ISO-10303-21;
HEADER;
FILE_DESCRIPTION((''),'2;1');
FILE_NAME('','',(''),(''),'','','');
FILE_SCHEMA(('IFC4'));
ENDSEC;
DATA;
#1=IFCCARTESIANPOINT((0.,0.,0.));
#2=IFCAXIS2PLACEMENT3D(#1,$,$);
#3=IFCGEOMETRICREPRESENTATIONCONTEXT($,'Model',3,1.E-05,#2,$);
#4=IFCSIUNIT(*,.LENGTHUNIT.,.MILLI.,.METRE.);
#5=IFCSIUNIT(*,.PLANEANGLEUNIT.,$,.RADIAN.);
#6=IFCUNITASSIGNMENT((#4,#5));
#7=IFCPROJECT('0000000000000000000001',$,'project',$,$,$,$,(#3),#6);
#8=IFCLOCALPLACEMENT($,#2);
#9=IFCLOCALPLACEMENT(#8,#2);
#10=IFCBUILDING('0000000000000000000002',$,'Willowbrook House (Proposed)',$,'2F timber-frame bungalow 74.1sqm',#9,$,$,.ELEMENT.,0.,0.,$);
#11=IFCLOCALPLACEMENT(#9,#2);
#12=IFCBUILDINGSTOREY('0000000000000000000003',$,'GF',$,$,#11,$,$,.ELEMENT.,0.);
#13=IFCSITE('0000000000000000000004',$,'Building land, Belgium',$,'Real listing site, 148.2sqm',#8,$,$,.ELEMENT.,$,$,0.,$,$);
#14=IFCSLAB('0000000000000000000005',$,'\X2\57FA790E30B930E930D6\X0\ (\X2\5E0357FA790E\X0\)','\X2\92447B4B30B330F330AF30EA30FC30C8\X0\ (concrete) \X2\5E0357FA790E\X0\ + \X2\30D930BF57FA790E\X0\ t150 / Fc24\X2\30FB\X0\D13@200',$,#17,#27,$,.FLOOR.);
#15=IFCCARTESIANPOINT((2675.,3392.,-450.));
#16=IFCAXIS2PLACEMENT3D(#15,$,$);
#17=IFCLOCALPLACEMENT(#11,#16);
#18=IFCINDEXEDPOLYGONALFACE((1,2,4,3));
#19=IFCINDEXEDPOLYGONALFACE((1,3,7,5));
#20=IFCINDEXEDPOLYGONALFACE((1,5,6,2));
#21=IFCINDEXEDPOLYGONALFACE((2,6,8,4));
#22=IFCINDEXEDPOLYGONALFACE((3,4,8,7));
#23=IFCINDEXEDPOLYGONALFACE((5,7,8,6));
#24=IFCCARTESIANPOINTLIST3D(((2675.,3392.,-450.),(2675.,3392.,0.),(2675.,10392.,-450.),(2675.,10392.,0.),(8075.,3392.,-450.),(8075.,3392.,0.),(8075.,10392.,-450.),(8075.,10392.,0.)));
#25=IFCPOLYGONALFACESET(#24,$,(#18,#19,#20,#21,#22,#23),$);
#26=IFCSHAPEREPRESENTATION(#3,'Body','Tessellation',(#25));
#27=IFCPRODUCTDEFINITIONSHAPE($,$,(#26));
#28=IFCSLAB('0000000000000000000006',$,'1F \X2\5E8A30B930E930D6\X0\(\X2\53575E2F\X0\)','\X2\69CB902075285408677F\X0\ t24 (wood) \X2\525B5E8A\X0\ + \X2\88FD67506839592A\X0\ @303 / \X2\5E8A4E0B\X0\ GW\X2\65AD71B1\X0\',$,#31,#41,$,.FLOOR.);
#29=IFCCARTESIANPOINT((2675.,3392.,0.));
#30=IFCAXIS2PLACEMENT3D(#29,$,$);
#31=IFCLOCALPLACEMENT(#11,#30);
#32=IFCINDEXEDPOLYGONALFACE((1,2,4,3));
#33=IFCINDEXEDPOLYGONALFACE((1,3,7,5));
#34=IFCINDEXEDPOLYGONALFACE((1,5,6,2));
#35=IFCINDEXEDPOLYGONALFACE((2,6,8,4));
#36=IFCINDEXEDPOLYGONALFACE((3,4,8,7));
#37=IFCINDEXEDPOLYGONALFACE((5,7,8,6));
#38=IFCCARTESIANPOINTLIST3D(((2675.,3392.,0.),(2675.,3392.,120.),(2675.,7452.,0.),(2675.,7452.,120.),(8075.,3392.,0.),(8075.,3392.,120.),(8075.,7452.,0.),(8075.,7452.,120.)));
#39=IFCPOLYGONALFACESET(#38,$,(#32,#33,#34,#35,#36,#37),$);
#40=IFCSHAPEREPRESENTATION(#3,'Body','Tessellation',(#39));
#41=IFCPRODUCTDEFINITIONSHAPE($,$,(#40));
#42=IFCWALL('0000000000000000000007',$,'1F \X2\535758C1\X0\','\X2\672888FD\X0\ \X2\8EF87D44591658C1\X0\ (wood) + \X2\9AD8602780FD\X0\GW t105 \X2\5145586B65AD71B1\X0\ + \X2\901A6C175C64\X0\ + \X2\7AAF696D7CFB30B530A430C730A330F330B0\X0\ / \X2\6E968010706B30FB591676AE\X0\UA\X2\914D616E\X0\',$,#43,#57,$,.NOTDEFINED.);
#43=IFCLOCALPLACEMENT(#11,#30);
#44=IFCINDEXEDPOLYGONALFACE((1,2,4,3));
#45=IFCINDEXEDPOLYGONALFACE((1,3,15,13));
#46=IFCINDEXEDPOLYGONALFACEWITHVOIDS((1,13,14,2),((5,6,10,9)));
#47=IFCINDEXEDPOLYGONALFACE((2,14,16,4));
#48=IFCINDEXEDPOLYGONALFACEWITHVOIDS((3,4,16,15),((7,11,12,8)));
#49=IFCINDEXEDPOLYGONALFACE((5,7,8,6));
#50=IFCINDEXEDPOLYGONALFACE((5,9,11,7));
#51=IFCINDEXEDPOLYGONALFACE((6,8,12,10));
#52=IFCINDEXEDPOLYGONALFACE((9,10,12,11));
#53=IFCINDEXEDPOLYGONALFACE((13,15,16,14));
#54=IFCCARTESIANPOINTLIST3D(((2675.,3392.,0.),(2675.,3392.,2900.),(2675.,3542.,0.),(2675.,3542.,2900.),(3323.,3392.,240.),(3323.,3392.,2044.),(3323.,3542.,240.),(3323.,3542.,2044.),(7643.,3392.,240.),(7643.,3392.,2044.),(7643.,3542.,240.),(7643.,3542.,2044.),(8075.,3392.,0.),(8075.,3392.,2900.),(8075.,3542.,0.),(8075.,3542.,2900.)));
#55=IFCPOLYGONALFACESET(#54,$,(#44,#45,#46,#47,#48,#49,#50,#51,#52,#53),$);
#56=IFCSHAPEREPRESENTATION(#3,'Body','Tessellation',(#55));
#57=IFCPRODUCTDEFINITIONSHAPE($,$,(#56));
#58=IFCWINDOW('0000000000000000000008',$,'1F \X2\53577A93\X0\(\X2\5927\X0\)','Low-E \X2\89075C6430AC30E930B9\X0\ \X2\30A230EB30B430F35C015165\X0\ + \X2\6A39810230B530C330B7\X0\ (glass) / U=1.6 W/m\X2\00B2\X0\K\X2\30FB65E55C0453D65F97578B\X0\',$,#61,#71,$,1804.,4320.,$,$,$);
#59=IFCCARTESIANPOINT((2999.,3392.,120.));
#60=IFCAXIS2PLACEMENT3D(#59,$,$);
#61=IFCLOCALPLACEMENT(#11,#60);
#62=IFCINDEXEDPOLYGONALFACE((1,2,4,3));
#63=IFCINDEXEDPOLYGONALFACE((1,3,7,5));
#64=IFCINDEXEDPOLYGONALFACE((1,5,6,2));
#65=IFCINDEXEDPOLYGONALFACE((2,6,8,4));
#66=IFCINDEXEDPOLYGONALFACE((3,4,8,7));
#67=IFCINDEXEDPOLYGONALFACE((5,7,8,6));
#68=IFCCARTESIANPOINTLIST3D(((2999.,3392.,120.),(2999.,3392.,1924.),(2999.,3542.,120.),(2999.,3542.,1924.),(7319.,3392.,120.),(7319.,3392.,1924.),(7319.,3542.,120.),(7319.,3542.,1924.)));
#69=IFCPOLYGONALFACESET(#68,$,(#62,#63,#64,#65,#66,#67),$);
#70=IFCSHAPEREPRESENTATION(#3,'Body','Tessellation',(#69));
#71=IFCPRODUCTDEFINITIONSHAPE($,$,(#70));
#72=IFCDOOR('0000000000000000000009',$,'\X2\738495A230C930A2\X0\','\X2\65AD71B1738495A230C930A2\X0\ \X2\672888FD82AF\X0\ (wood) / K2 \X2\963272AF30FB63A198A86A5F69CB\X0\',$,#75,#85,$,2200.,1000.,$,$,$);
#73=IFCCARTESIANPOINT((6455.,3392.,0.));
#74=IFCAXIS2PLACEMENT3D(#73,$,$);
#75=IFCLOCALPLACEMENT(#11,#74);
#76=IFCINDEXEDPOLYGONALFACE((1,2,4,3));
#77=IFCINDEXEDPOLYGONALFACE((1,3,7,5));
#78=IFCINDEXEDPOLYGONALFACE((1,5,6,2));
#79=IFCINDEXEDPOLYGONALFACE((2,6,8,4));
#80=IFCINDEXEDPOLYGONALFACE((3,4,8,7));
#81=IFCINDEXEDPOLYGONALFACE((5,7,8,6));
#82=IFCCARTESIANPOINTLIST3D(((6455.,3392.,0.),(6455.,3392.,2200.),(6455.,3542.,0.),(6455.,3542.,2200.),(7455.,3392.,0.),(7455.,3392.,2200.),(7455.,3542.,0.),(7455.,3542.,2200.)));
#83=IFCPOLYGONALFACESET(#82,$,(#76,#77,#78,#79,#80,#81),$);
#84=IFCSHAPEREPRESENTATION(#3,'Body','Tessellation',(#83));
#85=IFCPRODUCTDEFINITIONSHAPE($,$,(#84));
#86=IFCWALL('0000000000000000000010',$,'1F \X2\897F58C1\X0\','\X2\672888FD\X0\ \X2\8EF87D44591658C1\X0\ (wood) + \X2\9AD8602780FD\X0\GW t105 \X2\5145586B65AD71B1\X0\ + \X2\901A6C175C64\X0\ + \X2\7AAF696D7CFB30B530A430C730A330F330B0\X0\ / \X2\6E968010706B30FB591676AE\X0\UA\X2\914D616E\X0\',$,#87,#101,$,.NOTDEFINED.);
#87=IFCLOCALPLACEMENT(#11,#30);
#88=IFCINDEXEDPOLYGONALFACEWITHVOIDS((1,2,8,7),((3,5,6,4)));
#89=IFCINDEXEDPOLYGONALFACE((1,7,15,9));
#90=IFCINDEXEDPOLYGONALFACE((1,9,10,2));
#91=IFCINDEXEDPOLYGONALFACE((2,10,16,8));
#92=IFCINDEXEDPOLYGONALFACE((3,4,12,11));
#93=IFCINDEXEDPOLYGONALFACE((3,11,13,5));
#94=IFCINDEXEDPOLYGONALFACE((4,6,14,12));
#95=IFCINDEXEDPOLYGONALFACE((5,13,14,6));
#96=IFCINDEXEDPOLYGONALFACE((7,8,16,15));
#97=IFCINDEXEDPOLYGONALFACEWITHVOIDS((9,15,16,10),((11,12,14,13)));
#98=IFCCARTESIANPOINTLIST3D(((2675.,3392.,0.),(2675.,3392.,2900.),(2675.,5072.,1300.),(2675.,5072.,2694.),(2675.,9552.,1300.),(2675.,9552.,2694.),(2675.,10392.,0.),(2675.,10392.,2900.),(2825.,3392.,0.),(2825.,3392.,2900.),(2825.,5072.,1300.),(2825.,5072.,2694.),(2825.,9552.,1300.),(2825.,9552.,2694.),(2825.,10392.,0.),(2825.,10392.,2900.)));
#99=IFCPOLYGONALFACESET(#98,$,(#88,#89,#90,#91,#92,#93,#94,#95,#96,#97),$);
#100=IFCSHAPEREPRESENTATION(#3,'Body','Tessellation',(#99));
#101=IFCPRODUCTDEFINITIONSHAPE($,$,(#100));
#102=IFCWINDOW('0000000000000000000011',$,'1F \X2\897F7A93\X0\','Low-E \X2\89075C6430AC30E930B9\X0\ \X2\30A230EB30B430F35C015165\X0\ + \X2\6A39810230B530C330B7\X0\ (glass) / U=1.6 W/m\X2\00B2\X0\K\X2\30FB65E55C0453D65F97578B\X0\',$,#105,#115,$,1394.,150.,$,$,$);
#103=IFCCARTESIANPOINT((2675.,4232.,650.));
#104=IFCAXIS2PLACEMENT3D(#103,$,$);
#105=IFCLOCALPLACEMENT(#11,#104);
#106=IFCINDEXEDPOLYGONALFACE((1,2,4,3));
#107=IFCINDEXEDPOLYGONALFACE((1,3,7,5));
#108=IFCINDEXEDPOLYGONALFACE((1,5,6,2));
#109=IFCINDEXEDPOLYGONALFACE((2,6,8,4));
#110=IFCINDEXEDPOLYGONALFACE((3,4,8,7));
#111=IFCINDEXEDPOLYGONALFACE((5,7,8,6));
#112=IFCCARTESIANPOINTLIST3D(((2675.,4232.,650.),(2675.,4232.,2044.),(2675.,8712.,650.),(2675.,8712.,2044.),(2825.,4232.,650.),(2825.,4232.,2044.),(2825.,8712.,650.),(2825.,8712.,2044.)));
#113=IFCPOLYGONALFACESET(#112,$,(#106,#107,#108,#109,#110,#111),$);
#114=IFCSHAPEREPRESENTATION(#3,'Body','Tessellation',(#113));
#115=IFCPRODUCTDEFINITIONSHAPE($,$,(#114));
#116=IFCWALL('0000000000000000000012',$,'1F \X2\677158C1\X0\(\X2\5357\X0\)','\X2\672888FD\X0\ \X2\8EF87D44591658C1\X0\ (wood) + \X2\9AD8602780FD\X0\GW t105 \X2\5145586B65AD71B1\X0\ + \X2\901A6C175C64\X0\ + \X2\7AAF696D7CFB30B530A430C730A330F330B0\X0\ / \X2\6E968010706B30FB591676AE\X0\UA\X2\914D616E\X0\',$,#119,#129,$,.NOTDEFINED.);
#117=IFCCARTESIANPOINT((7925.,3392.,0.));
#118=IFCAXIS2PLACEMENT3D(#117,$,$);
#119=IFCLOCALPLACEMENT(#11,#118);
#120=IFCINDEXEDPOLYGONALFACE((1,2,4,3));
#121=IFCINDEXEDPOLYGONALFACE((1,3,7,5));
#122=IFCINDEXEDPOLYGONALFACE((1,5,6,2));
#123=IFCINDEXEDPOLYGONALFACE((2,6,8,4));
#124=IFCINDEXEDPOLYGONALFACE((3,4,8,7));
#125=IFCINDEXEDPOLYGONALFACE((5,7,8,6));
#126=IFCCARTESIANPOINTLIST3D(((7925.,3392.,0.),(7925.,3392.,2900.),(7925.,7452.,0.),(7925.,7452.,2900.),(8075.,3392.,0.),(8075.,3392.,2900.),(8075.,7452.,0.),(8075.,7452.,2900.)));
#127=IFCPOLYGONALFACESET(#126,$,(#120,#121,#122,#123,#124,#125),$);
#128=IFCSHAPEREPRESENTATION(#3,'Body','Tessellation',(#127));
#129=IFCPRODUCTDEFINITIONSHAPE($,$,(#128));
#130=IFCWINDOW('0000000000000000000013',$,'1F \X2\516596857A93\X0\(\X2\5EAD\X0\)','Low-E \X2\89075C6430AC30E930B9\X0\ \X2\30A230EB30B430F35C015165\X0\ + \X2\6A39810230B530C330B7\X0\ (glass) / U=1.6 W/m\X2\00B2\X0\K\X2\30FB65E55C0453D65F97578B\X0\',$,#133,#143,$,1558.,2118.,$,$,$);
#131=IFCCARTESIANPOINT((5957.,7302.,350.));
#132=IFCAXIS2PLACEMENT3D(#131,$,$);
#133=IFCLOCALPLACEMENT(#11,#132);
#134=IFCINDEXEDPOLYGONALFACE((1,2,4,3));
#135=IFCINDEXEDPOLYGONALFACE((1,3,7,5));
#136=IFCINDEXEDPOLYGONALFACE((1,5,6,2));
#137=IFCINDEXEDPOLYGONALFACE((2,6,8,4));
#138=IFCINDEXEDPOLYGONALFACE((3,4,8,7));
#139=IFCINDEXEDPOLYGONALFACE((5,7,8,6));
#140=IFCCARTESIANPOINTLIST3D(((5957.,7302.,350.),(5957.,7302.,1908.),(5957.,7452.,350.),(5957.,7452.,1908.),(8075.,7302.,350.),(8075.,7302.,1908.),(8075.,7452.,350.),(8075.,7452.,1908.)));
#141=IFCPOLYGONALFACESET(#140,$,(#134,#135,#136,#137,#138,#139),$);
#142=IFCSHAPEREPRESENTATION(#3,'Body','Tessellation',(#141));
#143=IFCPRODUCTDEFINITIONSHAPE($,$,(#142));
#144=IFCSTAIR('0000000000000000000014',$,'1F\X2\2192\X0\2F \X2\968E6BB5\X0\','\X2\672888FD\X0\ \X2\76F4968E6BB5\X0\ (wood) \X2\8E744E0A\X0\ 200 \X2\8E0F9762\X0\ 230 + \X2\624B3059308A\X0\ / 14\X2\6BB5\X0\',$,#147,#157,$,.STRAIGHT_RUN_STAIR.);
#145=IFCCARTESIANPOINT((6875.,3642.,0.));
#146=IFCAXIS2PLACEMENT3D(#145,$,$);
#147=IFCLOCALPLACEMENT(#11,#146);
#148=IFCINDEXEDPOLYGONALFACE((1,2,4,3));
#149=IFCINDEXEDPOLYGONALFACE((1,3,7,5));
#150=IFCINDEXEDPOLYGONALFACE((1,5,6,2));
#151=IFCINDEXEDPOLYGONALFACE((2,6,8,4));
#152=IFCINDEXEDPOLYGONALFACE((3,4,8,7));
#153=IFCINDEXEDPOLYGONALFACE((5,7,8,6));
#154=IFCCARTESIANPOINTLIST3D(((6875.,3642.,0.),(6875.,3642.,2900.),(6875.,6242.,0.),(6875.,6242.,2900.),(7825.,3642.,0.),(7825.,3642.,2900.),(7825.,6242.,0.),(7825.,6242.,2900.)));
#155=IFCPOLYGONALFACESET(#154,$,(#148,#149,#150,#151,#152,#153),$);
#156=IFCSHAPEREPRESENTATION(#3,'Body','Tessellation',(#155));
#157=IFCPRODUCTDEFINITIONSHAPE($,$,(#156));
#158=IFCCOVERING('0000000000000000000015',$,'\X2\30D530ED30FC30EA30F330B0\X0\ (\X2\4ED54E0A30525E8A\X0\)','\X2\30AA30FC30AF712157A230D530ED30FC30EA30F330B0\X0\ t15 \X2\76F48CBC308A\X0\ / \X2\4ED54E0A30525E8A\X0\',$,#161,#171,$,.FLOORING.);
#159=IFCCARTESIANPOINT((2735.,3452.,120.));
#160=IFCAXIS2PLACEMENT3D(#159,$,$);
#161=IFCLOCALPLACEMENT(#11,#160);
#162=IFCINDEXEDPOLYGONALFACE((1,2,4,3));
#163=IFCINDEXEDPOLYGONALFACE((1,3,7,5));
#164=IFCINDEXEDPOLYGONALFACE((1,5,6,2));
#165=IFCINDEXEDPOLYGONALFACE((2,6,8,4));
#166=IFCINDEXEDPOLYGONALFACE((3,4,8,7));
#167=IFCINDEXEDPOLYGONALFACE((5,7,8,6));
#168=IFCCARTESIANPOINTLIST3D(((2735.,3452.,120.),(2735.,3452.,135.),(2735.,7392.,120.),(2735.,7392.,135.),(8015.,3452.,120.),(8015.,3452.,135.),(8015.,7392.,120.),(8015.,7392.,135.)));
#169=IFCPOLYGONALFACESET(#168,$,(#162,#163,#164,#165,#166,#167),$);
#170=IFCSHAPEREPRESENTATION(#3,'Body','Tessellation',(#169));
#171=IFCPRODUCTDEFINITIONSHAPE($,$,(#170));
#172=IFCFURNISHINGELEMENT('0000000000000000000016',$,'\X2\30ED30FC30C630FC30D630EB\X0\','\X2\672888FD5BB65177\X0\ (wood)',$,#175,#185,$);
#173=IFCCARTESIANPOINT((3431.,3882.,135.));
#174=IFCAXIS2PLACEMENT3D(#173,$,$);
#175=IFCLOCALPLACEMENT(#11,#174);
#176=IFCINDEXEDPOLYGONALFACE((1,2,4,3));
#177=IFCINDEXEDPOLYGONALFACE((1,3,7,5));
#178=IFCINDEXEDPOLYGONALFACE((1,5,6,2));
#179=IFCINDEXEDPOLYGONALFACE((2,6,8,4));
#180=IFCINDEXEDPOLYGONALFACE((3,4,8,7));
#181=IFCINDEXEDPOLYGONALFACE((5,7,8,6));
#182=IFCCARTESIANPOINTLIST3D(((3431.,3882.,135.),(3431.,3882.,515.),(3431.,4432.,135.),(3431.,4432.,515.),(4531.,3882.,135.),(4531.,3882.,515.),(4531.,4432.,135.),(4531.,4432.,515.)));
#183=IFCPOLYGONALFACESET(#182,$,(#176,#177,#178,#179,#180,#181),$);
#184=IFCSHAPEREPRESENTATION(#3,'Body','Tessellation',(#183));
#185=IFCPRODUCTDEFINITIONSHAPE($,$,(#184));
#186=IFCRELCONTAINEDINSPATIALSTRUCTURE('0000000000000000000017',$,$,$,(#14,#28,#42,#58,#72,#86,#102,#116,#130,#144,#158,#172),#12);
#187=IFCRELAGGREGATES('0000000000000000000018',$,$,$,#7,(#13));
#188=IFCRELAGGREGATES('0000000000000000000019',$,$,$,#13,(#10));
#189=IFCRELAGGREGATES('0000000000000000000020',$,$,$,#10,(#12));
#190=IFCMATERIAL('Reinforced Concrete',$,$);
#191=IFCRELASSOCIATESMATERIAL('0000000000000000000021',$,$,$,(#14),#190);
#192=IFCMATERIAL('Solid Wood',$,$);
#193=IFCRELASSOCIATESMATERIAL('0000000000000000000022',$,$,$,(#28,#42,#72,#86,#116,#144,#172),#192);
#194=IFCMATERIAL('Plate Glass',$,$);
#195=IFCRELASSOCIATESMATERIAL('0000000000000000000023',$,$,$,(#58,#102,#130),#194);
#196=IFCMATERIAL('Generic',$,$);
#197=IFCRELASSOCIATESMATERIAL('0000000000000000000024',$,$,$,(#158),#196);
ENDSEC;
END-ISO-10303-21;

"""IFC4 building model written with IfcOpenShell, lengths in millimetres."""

from ifc_helpers import new_model, si_unit, frame, frame_2d, origin, place, context, project, spatial, rectangle, extrude, material, element, fill, save


model = new_model("IFC4")

# Units and contexts
model_context = context("Model", 3, precision=1e-05, world=origin())
ifc_project = project(units=[si_unit("LENGTHUNIT", "METRE", prefix="MILLI"), si_unit("PLANEANGLEUNIT", "RADIAN")], contexts=[model_context])

# Site, building, storey
site_placement = place(None, origin())
site = spatial("IfcSite", under=ifc_project, at=site_placement, Name="Building land, Belgium", ObjectType="Real listing site, 148.2sqm", CompositionType="ELEMENT", RefElevation=0.0)
building_placement = place(site_placement, origin())
building = spatial("IfcBuilding", under=site, at=building_placement, Name="Willowbrook House (Proposed)", ObjectType="2F timber-frame bungalow 74.1sqm", CompositionType="ELEMENT", ElevationOfRefHeight=0.0, ElevationOfTerrain=0.0)
storey_placement = place(building_placement, origin())
storey = spatial("IfcBuildingStorey", under=building, at=storey_placement, Name="GF", CompositionType="ELEMENT", Elevation=0.0)

# Slabs
ifc_material_1 = material(Name="Reinforced Concrete")
slab_1_placement = place(storey_placement, frame((2675.0, 3392.0, -450.0)))
element("IfcSlab", 1, at=slab_1_placement, inside=storey, material=ifc_material_1, Name="基礎スラブ (布基礎)", Description="鉄筋コンクリート (concrete) 布基礎 + ベタ基礎 t150 / Fc24・D13@200", PredefinedType="FLOOR", context=model_context, shape_type="SweptSolid", body=[
    extrude(rectangle(XDim=5400.0, YDim=7000.0, at=frame_2d((2700.0, 3500.0))), frame((2675.0, 3392.0, -450.0)), (0.0, 0.0, 1.0), 450.0),
])
ifc_material_2 = material(Name="Solid Wood")
slab_2_placement = place(storey_placement, frame((2675.0, 3392.0, 0.0)))
element("IfcSlab", 2, at=slab_2_placement, inside=storey, material=ifc_material_2, Name="1F 床スラブ(南帯)", Description="構造用合板 t24 (wood) 剛床 + 製材根太 @303 / 床下 GW断熱", PredefinedType="FLOOR", context=model_context, shape_type="SweptSolid", body=[
    extrude(rectangle(XDim=5400.0, YDim=4060.0, at=frame_2d((2700.0, 2030.0))), frame((2675.0, 3392.0, 0.0)), (0.0, 0.0, 1.0), 120.0),
])

# Wall, openings, window, door
wall_1_placement = place(storey_placement, frame((2675.0, 3392.0, 0.0)))
wall_1 = element("IfcWall", 3, at=wall_1_placement, inside=storey, material=ifc_material_2, Name="1F 南壁", Description="木製 軸組外壁 (wood) + 高性能GW t105 充填断熱 + 通気層 + 窯業系サイディング / 準耐火・外皮UA配慮", PredefinedType="NOTDEFINED", context=model_context, shape_type="SweptSolid", body=[
    extrude(rectangle(XDim=5400.0, YDim=150.0, at=frame_2d((2700.0, 75.0))), frame((2675.0, 3392.0, 0.0)), (0.0, 0.0, 1.0), 2900.0),
])
opening_1_placement = place(storey_placement, frame((2999.0, 3392.0, 120.0)))
opening_1 = element("IfcOpeningElement", 4, at=opening_1_placement, cuts=wall_1, PredefinedType="NOTDEFINED", context=model_context, shape_type="SweptSolid", body=[
    extrude(rectangle(XDim=4320.0, YDim=150.0, at=frame_2d((2160.0, 75.0))), frame((2999.0, 3392.0, 120.0)), (0.0, 0.0, 1.0), 1804.0),
])
opening_2_placement = place(storey_placement, frame((6455.0, 3392.0, 0.0)))
opening_2 = element("IfcOpeningElement", 5, at=opening_2_placement, cuts=wall_1, PredefinedType="NOTDEFINED", context=model_context, shape_type="SweptSolid", body=[
    extrude(rectangle(XDim=1000.0, YDim=150.0, at=frame_2d((500.0, 75.0))), frame((6455.0, 3392.0, 0.0)), (0.0, 0.0, 1.0), 2200.0),
])
ifc_material_3 = material(Name="Plate Glass")
window_1_placement = place(storey_placement, frame((2999.0, 3392.0, 120.0)))
window_1 = element("IfcWindow", 6, at=window_1_placement, inside=storey, material=ifc_material_3, Name="1F 南窓(大)", Description="Low-E 複層ガラス アルゴン封入 + 樹脂サッシ (glass) / U=1.6 W/m²K・日射取得型", OverallHeight=1804.0, OverallWidth=4320.0, context=model_context, shape_type="SweptSolid", body=[
    extrude(rectangle(XDim=4320.0, YDim=150.0, at=frame_2d((2160.0, 75.0))), frame((2999.0, 3392.0, 120.0)), (0.0, 0.0, 1.0), 1804.0),
])
fill(opening_1, window_1)
door_1_placement = place(storey_placement, frame((6455.0, 3392.0, 0.0)))
door_1 = element("IfcDoor", 7, at=door_1_placement, inside=storey, material=ifc_material_2, Name="玄関ドア", Description="断熱玄関ドア 木製芯 (wood) / K2 防犯・採風機構", OverallHeight=2200.0, OverallWidth=1000.0, context=model_context, shape_type="SweptSolid", body=[
    extrude(rectangle(XDim=1000.0, YDim=150.0, at=frame_2d((500.0, 75.0))), frame((6455.0, 3392.0, 0.0)), (0.0, 0.0, 1.0), 2200.0),
])
fill(opening_2, door_1)

# Walls, openings, windows
wall_2_placement = place(storey_placement, frame((2675.0, 3392.0, 0.0)))
wall_2 = element("IfcWall", 8, at=wall_2_placement, inside=storey, material=ifc_material_2, Name="1F 西壁", Description="木製 軸組外壁 (wood) + 高性能GW t105 充填断熱 + 通気層 + 窯業系サイディング / 準耐火・外皮UA配慮", PredefinedType="NOTDEFINED", context=model_context, shape_type="SweptSolid", body=[
    extrude(rectangle(XDim=150.0, YDim=7000.0, at=frame_2d((75.0, 3500.0))), frame((2675.0, 3392.0, 0.0)), (0.0, 0.0, 1.0), 2900.0),
])
opening_3_placement = place(storey_placement, frame((2675.0, 4232.0, 650.0)))
opening_3 = element("IfcOpeningElement", 9, at=opening_3_placement, cuts=wall_2, PredefinedType="NOTDEFINED", context=model_context, shape_type="SweptSolid", body=[
    extrude(rectangle(XDim=150.0, YDim=4480.0, at=frame_2d((75.0, 2240.0))), frame((2675.0, 4232.0, 650.0)), (0.0, 0.0, 1.0), 1394.0),
])
window_2_placement = place(storey_placement, frame((2675.0, 4232.0, 650.0)))
window_2 = element("IfcWindow", 10, at=window_2_placement, inside=storey, material=ifc_material_3, Name="1F 西窓", Description="Low-E 複層ガラス アルゴン封入 + 樹脂サッシ (glass) / U=1.6 W/m²K・日射取得型", OverallHeight=1394.0, OverallWidth=150.0, context=model_context, shape_type="SweptSolid", body=[
    extrude(rectangle(XDim=150.0, YDim=4480.0, at=frame_2d((75.0, 2240.0))), frame((2675.0, 4232.0, 650.0)), (0.0, 0.0, 1.0), 1394.0),
])
fill(opening_3, window_2)
wall_3_placement = place(storey_placement, frame((7925.0, 3392.0, 0.0)))
wall_3 = element("IfcWall", 11, at=wall_3_placement, inside=storey, material=ifc_material_2, Name="1F 東壁(南)", Description="木製 軸組外壁 (wood) + 高性能GW t105 充填断熱 + 通気層 + 窯業系サイディング / 準耐火・外皮UA配慮", PredefinedType="NOTDEFINED", context=model_context, shape_type="SweptSolid", body=[
    extrude(rectangle(XDim=150.0, YDim=4060.0, at=frame_2d((75.0, 2030.0))), frame((7925.0, 3392.0, 0.0)), (0.0, 0.0, 1.0), 2900.0),
])
opening_4_placement = place(storey_placement, frame((5957.0, 7302.0, 350.0)))
opening_4 = element("IfcOpeningElement", 12, at=opening_4_placement, cuts=wall_3, PredefinedType="NOTDEFINED", context=model_context, shape_type="SweptSolid", body=[
    extrude(rectangle(XDim=2118.0, YDim=150.0, at=frame_2d((1059.0, 75.0))), frame((5957.0, 7302.0, 350.0)), (0.0, 0.0, 1.0), 1558.0),
])
window_3_placement = place(storey_placement, frame((5957.0, 7302.0, 350.0)))
window_3 = element("IfcWindow", 13, at=window_3_placement, inside=storey, material=ifc_material_3, Name="1F 入隅窓(庭)", Description="Low-E 複層ガラス アルゴン封入 + 樹脂サッシ (glass) / U=1.6 W/m²K・日射取得型", OverallHeight=1558.0, OverallWidth=2118.0, context=model_context, shape_type="SweptSolid", body=[
    extrude(rectangle(XDim=2118.0, YDim=150.0, at=frame_2d((1059.0, 75.0))), frame((5957.0, 7302.0, 350.0)), (0.0, 0.0, 1.0), 1558.0),
])
fill(opening_4, window_3)

# Stair
stair_placement = place(storey_placement, frame((6875.0, 3642.0, 0.0)))
element("IfcStair", 14, at=stair_placement, inside=storey, material=ifc_material_2, Name="1F→2F 階段", Description="木製 直階段 (wood) 蹴上 200 踏面 230 + 手すり / 14段", PredefinedType="STRAIGHT_RUN_STAIR", context=model_context, shape_type="SweptSolid", body=[
    extrude(rectangle(XDim=950.0, YDim=2600.0, at=frame_2d((475.0, 1300.0))), frame((6875.0, 3642.0, 0.0)), (0.0, 0.0, 1.0), 2900.0),
])

# Covering
ifc_material_4 = material(Name="Generic")
covering_placement = place(storey_placement, frame((2735.0, 3452.0, 120.0)))
element("IfcCovering", 15, at=covering_placement, inside=storey, material=ifc_material_4, Name="フローリング (仕上げ床)", Description="オーク無垢フローリング t15 直貼り / 仕上げ床", PredefinedType="FLOORING", context=model_context, shape_type="SweptSolid", body=[
    extrude(rectangle(XDim=5280.0, YDim=3940.0, at=frame_2d((2640.0, 1970.0))), frame((2735.0, 3452.0, 120.0)), (0.0, 0.0, 1.0), 15.0),
])

# Furnishing element
furnishing_1_placement = place(storey_placement, frame((3431.0, 3882.0, 135.0)))
element("IfcFurnishingElement", 16, at=furnishing_1_placement, inside=storey, material=ifc_material_2, Name="ローテーブル", Description="木製家具 (wood)", context=model_context, shape_type="SweptSolid", body=[
    extrude(rectangle(XDim=1100.0, YDim=550.0, at=frame_2d((550.0, 275.0))), frame((3431.0, 3882.0, 135.0)), (0.0, 0.0, 1.0), 380.0),
])

save(model, "model.ifc")
